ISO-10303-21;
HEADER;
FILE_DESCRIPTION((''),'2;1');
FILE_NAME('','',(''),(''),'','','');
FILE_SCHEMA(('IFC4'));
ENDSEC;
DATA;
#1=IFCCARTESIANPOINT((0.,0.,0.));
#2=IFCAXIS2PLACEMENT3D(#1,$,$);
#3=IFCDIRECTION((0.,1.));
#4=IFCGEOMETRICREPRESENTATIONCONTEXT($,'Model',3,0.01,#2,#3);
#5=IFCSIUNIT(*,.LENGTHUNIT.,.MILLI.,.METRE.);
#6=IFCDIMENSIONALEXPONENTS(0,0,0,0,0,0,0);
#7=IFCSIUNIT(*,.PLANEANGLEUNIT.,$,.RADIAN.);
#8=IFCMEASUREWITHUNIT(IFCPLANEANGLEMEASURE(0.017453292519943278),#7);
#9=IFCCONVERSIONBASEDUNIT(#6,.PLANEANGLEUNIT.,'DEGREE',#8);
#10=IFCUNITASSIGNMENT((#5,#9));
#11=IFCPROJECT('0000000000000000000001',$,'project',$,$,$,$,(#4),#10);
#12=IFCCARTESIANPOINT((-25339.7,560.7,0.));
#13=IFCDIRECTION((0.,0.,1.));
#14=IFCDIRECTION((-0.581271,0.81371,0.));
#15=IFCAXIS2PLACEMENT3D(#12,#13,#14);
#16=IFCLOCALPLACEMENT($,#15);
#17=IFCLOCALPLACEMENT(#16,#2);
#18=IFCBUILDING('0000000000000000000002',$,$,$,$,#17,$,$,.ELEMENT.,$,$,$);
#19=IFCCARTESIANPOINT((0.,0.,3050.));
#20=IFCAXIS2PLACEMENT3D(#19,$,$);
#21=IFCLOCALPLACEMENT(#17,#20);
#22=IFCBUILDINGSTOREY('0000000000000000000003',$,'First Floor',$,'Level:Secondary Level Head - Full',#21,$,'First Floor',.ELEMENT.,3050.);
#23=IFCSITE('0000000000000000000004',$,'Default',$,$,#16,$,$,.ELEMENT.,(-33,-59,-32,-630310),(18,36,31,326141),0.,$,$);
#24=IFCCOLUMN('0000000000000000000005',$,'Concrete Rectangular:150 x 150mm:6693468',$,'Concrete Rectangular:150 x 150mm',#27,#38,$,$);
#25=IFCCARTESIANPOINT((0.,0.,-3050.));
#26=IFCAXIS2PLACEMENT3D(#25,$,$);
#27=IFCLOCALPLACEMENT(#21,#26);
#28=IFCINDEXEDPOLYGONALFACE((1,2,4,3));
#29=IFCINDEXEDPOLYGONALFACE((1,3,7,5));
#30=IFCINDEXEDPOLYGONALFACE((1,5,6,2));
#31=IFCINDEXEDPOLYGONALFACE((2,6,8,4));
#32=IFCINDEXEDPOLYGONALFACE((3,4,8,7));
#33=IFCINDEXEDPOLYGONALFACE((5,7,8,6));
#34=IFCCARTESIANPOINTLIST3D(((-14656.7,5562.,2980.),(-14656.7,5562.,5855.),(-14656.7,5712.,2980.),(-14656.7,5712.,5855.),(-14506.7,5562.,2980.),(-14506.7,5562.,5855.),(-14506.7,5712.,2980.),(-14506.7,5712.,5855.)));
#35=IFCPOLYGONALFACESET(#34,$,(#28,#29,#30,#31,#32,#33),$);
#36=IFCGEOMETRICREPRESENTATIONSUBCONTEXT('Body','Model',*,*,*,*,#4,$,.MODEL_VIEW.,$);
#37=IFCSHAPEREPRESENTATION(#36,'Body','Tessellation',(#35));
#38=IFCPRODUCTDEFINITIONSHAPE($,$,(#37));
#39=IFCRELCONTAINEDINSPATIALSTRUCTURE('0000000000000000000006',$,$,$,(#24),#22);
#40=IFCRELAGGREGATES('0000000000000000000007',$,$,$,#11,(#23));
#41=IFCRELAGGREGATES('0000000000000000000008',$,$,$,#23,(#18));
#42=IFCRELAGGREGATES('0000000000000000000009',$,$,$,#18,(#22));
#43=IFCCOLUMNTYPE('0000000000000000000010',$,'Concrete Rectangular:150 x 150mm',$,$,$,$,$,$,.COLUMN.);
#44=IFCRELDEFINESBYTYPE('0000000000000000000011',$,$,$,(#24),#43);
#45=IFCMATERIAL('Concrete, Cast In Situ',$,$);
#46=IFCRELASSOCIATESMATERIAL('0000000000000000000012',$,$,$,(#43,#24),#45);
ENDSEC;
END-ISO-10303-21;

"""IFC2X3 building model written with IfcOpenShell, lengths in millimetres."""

from ifc_helpers import new_model, entity, si_unit, converted_unit, direction, frame, frame_2d, origin, place, context, subcontext, project, spatial, rectangle, extrude, source, transform, mapped, material, type_object, type_shapes, element, save


model = new_model("IFC2X3")

# Units and contexts
model_context = context("Model", 3, precision=0.01, world=origin(), true_north=direction((0.0, 1.0)))
body_context = subcontext(model_context, "Body", "Model", "MODEL_VIEW")
ifc_project = project(units=[si_unit("LENGTHUNIT", "METRE", prefix="MILLI"), converted_unit("PLANEANGLEUNIT", "DEGREE", entity("IfcPlaneAngleMeasure", 0.017453292519943278), si_unit("PLANEANGLEUNIT", "RADIAN"), dimensions=[0, 0, 0, 0, 0, 0, 0])], contexts=[model_context])

# Site, building, storey
site_placement = place(None, frame((-25339.7, 560.7, 0.0), z_axis=(0.0, 0.0, 1.0), x_axis=(-0.581271, 0.81371, 0.0)))
site = spatial("IfcSite", under=ifc_project, at=site_placement, Name="Default", CompositionType="ELEMENT", RefLatitude=(-33, -59, -32, -630310), RefLongitude=(18, 36, 31, 326141), RefElevation=0.0)
building_placement = place(site_placement, origin())
building = spatial("IfcBuilding", under=site, at=building_placement, CompositionType="ELEMENT")
storey_placement = place(building_placement, frame((0.0, 0.0, 3050.0)))
storey = spatial("IfcBuildingStorey", under=building, at=storey_placement, Name="First Floor", ObjectType="Level:Secondary Level Head - Full", LongName="First Floor", CompositionType="ELEMENT", Elevation=3050.0)

# Column
ifc_material = material(Name="Concrete, Cast In Situ")
column_type = type_object("IfcColumnType", Name="Concrete Rectangular:150 x 150mm", PredefinedType="COLUMN", material=ifc_material)
shared_shape = source(origin(), body_context, "Body", "SweptSolid", [
    extrude(rectangle(XDim=150.0, YDim=150.0, at=frame_2d((0.0, 0.0), x_axis=(1.0, 0.0))), frame((-14581.7, 5637.0, 2980.0), z_axis=(0.0, 0.0, 1.0), x_axis=(-1.0, 0.0, 0.0)), (0.0, 0.0, 1.0), 2875.0),
])
type_shapes(column_type, [shared_shape])
column_placement = place(storey_placement, frame((0.0, 0.0, -3050.0)))
element("IfcColumn", 1, at=column_placement, inside=storey, type_object=column_type, material=ifc_material, Name="Concrete Rectangular:150 x 150mm:6693468", ObjectType="Concrete Rectangular:150 x 150mm", context=body_context, shape_type="MappedRepresentation", body=[
    mapped(shared_shape, transform((0.0, 0.0, 0.0), scale=1.0)),
])

save(model, "model.ifc")
